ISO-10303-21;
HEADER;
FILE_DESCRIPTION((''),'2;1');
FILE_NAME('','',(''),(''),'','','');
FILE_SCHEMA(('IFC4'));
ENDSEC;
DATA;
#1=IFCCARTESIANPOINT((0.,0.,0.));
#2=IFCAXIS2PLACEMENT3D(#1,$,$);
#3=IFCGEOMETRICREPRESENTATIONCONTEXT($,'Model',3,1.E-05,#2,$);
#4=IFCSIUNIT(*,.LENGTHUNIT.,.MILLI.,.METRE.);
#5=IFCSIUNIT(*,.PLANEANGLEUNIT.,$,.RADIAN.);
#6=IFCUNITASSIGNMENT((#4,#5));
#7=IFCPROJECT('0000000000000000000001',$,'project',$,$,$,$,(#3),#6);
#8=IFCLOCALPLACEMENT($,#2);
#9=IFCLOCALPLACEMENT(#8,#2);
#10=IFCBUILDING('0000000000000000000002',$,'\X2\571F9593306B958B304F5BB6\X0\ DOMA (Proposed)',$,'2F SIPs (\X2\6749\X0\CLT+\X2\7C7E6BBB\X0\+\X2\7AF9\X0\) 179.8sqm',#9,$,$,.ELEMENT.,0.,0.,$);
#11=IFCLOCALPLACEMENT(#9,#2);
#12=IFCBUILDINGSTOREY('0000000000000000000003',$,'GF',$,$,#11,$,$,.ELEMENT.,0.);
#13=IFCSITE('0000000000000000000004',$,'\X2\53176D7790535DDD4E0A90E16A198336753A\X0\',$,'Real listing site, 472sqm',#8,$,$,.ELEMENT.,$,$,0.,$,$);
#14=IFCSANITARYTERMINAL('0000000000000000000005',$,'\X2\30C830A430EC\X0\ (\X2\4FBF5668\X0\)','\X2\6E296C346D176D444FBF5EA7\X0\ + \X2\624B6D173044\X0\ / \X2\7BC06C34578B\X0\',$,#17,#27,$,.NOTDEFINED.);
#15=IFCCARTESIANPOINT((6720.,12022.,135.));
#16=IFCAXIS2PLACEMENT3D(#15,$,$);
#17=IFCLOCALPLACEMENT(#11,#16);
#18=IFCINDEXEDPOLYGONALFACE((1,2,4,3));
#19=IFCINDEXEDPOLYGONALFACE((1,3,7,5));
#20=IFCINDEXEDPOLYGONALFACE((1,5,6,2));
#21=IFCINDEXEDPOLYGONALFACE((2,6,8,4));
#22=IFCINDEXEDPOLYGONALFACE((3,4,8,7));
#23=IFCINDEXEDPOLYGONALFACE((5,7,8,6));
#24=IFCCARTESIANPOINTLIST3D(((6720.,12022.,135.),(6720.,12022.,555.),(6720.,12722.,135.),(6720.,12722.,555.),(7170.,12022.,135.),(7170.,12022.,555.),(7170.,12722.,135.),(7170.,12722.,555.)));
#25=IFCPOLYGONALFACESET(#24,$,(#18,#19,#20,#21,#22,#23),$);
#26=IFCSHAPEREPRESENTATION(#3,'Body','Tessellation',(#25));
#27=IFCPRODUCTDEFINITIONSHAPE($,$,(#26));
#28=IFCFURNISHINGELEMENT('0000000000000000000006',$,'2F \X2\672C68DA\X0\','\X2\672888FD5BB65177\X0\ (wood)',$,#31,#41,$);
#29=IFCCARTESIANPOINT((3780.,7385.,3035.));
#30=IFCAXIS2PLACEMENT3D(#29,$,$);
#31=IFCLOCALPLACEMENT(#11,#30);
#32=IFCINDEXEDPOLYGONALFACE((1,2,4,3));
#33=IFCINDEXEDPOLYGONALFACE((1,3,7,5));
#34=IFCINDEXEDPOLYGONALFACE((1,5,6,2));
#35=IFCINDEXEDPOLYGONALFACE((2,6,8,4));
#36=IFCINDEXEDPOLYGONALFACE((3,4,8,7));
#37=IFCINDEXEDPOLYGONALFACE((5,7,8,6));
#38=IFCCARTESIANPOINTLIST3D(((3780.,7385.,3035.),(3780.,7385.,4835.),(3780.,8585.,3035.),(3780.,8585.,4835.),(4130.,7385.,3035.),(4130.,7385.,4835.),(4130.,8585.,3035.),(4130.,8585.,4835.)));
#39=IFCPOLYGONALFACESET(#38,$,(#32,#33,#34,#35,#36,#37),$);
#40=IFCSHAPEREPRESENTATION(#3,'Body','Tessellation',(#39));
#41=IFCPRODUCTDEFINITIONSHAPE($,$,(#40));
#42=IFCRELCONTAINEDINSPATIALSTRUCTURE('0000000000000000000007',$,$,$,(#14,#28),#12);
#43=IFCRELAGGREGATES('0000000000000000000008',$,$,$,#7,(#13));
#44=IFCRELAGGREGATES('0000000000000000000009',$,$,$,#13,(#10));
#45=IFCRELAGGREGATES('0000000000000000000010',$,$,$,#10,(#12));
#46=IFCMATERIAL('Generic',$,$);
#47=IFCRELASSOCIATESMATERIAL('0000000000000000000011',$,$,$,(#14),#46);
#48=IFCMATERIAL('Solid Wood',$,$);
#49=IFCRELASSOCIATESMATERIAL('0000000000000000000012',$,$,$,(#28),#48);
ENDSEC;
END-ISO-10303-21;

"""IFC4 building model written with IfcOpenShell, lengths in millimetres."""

from ifc_helpers import new_model, si_unit, frame, frame_2d, origin, place, context, project, spatial, rectangle, extrude, material, element, save


model = new_model("IFC4")

# Units and contexts
model_context = context("Model", 3, precision=1e-05, world=origin())
ifc_project = project(units=[si_unit("LENGTHUNIT", "METRE", prefix="MILLI"), si_unit("PLANEANGLEUNIT", "RADIAN")], contexts=[model_context])

# Site, building, storey
site_placement = place(None, origin())
site = spatial("IfcSite", under=ifc_project, at=site_placement, Name="北海道川上郡標茶町", ObjectType="Real listing site, 472sqm", CompositionType="ELEMENT", RefElevation=0.0)
building_placement = place(site_placement, origin())
building = spatial("IfcBuilding", under=site, at=building_placement, Name="土間に開く家 DOMA (Proposed)", ObjectType="2F SIPs (杉CLT+籾殻+竹) 179.8sqm", CompositionType="ELEMENT", ElevationOfRefHeight=0.0, ElevationOfTerrain=0.0)
storey_placement = place(building_placement, origin())
storey = spatial("IfcBuildingStorey", under=building, at=storey_placement, Name="GF", CompositionType="ELEMENT", Elevation=0.0)

# Shared definitions
ifc_material_1 = material(Name="Solid Wood")
ifc_material_2 = material(Name="Generic")

# Sanitary terminal
sanitary_terminal_1_placement = place(storey_placement, frame((6720.0, 12022.0, 135.0)))
element("IfcSanitaryTerminal", 1, at=sanitary_terminal_1_placement, inside=storey, material=ifc_material_2, Name="トイレ (便器)", Description="温水洗浄便座 + 手洗い / 節水型", PredefinedType="NOTDEFINED", context=model_context, shape_type="SweptSolid", body=[
    extrude(rectangle(XDim=450.0, YDim=700.0, at=frame_2d((225.0, 350.0))), frame((6720.0, 12022.0, 135.0)), (0.0, 0.0, 1.0), 420.0),
])

# Furnishing element
furnishing_placement = place(storey_placement, frame((3780.0, 7385.0, 3035.0)))
element("IfcFurnishingElement", 2, at=furnishing_placement, inside=storey, material=ifc_material_1, Name="2F 本棚", Description="木製家具 (wood)", context=model_context, shape_type="SweptSolid", body=[
    extrude(rectangle(XDim=350.0, YDim=1200.0, at=frame_2d((175.0, 600.0))), frame((3780.0, 7385.0, 3035.0)), (0.0, 0.0, 1.0), 1800.0),
])

save(model, "model.ifc")
